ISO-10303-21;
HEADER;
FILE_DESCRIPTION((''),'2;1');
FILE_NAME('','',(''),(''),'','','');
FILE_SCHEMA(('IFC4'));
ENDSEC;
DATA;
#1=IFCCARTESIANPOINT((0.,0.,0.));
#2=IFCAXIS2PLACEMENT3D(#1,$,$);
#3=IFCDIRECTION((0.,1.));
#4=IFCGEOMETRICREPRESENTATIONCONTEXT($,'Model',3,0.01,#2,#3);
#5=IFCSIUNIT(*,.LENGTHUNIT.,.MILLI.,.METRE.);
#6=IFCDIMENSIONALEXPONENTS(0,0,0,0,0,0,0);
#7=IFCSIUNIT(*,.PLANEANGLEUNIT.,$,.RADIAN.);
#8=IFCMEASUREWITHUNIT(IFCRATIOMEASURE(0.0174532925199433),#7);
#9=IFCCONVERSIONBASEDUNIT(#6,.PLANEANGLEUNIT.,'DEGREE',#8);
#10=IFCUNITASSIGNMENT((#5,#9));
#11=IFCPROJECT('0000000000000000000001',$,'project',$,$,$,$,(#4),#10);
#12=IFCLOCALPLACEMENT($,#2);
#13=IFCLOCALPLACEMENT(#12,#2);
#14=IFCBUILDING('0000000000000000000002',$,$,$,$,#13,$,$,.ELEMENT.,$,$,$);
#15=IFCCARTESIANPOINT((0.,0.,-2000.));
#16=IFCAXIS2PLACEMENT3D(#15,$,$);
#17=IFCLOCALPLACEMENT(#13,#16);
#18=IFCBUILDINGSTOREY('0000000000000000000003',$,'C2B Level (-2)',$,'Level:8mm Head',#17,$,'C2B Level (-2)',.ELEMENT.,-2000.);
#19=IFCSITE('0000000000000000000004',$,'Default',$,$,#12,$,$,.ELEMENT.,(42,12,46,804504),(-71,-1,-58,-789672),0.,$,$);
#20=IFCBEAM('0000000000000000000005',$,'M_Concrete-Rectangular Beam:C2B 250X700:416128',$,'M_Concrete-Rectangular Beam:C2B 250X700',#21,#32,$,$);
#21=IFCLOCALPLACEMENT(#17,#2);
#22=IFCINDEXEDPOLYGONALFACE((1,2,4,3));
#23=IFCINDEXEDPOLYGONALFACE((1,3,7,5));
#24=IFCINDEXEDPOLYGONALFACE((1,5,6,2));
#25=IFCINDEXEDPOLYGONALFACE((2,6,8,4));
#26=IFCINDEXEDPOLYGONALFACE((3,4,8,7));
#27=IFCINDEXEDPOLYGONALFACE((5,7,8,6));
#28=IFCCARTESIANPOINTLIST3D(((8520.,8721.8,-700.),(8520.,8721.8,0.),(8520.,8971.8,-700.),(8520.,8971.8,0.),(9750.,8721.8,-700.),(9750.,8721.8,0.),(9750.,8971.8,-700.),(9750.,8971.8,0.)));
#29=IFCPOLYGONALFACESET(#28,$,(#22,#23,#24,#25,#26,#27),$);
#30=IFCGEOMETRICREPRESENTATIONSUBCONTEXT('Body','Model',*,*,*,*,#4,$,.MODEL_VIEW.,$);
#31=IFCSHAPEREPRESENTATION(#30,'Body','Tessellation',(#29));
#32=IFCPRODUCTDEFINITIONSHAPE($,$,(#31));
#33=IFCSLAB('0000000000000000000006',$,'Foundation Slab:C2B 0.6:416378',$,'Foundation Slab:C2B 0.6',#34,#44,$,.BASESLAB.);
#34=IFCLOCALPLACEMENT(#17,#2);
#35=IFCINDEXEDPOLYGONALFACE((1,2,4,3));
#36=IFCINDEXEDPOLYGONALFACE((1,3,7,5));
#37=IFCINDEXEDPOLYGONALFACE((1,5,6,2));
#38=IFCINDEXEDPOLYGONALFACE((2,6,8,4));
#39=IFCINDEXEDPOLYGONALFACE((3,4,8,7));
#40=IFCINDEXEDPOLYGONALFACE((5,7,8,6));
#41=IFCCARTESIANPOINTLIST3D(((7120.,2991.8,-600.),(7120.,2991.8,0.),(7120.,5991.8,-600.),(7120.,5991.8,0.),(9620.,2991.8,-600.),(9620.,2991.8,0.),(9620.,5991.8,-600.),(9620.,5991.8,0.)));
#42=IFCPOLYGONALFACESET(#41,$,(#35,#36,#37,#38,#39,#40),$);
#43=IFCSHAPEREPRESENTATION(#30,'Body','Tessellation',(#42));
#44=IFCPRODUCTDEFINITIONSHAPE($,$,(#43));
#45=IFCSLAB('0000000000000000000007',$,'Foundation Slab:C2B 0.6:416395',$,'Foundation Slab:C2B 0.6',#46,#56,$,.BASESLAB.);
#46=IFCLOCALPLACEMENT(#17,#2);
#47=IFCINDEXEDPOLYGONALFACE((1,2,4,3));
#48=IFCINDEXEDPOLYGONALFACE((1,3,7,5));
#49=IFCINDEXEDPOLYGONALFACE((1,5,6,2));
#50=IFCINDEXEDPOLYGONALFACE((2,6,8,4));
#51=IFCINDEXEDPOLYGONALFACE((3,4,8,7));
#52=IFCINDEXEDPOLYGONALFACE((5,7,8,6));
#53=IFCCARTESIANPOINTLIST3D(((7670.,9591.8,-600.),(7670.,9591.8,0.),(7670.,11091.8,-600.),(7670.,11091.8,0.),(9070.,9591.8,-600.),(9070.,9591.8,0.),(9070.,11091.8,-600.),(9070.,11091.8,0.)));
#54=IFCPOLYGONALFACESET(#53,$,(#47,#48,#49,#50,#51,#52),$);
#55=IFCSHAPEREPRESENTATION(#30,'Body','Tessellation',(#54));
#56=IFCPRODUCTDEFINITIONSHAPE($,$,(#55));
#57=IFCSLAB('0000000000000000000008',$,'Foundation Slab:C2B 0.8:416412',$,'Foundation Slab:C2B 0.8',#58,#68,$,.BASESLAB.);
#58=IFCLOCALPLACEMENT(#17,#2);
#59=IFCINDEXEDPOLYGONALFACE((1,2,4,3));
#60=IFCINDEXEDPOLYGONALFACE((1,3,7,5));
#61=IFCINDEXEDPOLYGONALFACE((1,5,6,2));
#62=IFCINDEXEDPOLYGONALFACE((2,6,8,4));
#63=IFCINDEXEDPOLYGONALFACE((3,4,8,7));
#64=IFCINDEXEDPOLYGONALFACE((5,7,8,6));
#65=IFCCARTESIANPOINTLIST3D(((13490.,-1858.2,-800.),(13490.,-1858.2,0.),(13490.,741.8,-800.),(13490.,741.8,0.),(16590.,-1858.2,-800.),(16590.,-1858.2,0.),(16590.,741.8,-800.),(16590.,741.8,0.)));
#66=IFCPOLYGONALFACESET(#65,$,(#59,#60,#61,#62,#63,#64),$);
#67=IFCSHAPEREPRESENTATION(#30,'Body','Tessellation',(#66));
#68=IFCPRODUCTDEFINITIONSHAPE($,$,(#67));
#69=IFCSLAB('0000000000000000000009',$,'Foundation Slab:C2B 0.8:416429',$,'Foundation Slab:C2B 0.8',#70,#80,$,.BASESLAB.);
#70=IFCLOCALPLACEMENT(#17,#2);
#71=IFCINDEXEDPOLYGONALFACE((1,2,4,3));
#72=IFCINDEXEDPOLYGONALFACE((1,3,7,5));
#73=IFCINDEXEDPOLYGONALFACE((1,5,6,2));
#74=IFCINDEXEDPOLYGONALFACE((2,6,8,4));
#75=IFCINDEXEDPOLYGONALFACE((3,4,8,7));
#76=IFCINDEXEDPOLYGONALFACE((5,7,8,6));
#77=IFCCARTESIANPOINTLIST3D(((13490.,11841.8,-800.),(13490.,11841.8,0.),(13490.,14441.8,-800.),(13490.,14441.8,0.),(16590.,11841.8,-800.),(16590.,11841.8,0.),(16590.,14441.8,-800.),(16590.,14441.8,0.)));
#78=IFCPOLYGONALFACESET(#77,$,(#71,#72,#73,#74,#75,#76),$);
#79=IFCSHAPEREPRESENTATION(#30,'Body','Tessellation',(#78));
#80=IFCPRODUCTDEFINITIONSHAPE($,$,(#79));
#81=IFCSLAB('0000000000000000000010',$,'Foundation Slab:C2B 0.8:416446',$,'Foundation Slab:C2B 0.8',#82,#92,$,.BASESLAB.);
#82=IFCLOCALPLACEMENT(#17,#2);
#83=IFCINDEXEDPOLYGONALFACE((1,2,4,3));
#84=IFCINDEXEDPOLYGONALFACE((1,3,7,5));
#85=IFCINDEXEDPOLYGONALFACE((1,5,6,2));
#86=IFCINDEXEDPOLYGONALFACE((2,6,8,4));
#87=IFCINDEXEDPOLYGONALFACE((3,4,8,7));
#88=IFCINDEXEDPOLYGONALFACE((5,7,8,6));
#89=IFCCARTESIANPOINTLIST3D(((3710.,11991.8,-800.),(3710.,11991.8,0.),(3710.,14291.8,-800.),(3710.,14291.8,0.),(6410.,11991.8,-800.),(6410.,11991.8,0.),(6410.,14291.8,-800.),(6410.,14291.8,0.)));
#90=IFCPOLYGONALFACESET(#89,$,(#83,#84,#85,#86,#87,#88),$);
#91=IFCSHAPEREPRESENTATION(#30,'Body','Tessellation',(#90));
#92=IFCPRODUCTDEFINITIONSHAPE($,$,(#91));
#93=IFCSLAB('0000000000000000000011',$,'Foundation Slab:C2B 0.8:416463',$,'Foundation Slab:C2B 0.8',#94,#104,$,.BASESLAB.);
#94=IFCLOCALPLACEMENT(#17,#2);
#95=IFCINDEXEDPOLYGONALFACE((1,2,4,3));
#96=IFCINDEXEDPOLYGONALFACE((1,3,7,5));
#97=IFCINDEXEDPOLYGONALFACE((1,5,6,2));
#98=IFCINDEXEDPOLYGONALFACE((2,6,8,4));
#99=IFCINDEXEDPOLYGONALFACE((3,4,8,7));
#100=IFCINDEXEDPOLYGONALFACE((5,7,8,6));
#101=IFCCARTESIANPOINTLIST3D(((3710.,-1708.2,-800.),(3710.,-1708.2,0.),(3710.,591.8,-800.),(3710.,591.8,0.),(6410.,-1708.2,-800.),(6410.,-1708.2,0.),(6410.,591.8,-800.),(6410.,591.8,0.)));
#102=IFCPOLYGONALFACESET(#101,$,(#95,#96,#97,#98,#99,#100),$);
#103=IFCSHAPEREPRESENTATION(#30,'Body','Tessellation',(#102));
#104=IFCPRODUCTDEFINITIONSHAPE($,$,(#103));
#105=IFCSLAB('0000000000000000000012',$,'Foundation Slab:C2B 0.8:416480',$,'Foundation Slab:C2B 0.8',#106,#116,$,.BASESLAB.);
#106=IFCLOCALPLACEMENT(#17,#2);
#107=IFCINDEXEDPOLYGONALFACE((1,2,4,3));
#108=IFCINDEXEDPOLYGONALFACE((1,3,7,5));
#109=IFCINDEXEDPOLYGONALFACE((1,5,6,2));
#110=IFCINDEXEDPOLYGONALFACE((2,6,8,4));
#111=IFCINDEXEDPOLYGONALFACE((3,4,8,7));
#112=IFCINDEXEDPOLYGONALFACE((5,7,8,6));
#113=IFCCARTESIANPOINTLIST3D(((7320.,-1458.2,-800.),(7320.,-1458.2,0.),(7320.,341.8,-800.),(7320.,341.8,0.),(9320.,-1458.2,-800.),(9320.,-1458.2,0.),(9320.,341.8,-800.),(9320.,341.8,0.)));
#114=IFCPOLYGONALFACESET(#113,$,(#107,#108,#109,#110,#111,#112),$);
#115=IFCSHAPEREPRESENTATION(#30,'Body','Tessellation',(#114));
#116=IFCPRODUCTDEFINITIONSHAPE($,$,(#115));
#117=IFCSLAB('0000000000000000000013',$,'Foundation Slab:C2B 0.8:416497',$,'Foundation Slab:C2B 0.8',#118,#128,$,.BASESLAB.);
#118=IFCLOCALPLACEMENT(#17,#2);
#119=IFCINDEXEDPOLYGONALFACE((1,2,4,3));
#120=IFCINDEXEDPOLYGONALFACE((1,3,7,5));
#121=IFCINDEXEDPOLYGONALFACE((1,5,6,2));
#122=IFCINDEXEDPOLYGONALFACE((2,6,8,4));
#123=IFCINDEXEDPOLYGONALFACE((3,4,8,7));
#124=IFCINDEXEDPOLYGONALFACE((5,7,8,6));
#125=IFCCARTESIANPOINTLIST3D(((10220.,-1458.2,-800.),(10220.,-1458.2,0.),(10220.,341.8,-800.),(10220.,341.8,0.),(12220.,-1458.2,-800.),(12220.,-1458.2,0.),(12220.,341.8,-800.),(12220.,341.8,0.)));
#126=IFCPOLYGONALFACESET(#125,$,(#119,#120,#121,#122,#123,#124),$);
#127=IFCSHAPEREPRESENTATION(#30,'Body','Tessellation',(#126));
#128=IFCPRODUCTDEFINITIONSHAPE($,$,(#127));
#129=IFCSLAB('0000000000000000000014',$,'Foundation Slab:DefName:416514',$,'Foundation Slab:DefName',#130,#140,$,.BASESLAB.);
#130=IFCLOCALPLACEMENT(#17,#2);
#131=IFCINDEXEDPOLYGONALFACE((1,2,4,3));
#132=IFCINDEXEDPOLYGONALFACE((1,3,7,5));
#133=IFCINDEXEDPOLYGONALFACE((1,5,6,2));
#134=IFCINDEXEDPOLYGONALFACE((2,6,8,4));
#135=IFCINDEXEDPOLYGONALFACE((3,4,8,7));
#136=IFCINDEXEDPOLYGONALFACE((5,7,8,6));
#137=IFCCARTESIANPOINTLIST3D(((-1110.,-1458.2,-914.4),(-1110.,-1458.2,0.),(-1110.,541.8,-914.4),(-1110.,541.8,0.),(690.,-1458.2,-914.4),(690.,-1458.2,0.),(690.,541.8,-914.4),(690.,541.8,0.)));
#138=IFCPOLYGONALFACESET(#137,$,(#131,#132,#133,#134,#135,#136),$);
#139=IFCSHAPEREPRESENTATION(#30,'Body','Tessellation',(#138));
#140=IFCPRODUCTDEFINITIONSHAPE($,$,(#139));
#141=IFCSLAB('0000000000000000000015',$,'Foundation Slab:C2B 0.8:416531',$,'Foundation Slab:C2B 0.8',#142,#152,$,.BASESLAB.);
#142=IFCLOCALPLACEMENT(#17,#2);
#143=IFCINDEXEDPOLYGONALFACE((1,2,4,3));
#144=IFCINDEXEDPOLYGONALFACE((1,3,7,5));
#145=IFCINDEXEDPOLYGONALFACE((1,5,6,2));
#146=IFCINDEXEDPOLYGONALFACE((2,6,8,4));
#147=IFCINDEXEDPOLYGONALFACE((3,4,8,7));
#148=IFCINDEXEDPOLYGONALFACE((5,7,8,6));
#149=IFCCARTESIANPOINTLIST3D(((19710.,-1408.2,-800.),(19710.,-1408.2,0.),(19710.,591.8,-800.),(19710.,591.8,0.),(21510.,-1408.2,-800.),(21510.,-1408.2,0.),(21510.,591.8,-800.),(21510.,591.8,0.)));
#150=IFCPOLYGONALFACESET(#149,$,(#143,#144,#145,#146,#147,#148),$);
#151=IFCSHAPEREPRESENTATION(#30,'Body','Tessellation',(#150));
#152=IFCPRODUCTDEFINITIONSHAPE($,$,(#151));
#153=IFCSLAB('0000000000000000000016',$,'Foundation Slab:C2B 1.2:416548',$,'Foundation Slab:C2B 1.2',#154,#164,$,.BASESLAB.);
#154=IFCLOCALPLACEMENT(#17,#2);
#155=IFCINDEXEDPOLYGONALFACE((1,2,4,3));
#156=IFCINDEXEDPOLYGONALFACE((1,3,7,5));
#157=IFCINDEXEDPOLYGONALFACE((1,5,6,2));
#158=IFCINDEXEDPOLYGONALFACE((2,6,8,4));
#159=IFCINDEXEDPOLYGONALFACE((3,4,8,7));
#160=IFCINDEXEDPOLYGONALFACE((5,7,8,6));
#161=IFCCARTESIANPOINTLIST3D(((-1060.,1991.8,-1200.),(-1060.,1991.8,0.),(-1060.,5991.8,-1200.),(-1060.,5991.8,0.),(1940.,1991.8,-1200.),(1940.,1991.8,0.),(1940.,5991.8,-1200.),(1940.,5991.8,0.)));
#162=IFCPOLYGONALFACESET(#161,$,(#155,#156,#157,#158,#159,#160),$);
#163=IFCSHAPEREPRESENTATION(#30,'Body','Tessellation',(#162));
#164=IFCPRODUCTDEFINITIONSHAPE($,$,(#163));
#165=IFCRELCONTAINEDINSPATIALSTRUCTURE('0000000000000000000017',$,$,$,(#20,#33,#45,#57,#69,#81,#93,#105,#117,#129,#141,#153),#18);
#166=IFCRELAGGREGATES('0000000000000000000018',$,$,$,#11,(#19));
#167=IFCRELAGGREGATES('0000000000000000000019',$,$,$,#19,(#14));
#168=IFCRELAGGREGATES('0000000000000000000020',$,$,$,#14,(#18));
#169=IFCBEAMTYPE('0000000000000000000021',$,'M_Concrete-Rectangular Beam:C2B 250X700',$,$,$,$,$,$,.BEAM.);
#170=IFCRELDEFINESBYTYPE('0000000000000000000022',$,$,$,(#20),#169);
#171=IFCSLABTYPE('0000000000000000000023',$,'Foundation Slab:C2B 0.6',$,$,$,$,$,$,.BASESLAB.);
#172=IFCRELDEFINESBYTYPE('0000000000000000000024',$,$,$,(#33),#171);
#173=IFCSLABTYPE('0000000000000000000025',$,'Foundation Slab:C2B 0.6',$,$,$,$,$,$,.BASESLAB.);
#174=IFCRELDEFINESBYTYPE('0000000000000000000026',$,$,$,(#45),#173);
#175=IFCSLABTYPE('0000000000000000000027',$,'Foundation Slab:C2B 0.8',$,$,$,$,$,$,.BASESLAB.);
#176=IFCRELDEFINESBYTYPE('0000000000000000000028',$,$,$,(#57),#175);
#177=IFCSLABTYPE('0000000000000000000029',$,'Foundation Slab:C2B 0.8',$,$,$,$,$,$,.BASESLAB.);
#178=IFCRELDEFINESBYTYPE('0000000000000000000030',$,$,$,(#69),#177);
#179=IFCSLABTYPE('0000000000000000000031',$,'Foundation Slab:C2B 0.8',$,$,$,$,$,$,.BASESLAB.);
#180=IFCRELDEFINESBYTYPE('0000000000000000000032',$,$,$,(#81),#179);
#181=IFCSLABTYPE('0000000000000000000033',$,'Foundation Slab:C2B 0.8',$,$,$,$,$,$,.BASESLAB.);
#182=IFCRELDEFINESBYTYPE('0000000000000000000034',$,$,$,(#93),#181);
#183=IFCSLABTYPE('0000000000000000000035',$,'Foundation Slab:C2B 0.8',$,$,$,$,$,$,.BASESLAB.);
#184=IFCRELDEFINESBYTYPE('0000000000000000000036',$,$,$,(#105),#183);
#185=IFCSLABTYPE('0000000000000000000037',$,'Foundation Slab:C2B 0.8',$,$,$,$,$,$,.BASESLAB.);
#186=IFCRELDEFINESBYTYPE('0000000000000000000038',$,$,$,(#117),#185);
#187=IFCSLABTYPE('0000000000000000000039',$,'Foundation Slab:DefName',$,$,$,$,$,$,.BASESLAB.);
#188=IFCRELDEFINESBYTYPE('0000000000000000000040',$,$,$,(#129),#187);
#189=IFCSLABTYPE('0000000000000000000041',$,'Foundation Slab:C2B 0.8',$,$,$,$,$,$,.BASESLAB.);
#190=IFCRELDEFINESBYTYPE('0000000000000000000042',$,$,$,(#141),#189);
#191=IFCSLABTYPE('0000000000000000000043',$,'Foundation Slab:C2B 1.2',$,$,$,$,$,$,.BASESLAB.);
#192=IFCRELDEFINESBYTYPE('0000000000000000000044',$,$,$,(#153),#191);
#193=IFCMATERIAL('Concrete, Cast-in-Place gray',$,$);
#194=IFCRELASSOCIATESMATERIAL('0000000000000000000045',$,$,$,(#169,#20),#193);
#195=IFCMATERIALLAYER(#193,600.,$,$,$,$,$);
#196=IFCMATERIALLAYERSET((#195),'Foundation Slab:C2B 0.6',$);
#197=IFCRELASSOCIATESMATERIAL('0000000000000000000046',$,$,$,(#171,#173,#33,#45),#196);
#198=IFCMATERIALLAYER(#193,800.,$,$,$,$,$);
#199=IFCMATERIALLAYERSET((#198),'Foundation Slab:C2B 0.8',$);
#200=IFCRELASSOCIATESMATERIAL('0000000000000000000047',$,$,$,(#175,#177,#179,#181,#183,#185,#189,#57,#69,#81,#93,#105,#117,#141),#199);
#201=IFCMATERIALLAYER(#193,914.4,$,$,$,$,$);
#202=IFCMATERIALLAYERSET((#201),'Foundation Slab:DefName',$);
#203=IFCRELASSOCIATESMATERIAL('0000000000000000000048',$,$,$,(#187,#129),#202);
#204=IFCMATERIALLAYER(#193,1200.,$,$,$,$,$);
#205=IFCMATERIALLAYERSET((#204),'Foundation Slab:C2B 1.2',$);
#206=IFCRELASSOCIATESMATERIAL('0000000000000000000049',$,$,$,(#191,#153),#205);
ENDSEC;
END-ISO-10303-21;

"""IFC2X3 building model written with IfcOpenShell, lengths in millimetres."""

from ifc_helpers import new_model, entity, si_unit, converted_unit, direction, frame, frame_2d, origin, origin_2d_with_axis, place, context, subcontext, project, spatial, rectangle, extrude, material, layer, layer_set, layer_usage, type_object, element, save


model = new_model("IFC2X3")

# Units and contexts
model_context = context("Model", 3, precision=0.01, world=origin(), true_north=direction((0.0, 1.0)))
body_context = subcontext(model_context, "Body", "Model", "MODEL_VIEW")
ifc_project = project(units=[si_unit("LENGTHUNIT", "METRE", prefix="MILLI"), converted_unit("PLANEANGLEUNIT", "DEGREE", entity("IfcRatioMeasure", 0.0174532925199433), si_unit("PLANEANGLEUNIT", "RADIAN"), dimensions=[0, 0, 0, 0, 0, 0, 0])], contexts=[model_context])

# Site, building, storey
site_placement = place(None, origin())
site = spatial("IfcSite", under=ifc_project, at=site_placement, Name="Default", CompositionType="ELEMENT", RefLatitude=(42, 12, 46, 804504), RefLongitude=(-71, -1, -58, -789672), RefElevation=0.0)
building_placement = place(site_placement, origin())
building = spatial("IfcBuilding", under=site, at=building_placement, CompositionType="ELEMENT")
storey_placement = place(building_placement, frame((0.0, 0.0, -2000.0)))
storey = spatial("IfcBuildingStorey", under=building, at=storey_placement, Name="C2B Level (-2)", ObjectType="Level:8mm Head", LongName="C2B Level (-2)", CompositionType="ELEMENT", Elevation=-2000.0)

# Beam
ifc_material = material(Name="Concrete, Cast-in-Place gray")
beam_type = type_object("IfcBeamType", Name="M_Concrete-Rectangular Beam:C2B 250X700", PredefinedType="BEAM", material=ifc_material)
beam_1_placement = place(storey_placement, frame((8395.0, 8846.8, 0.0)))
element("IfcBeam", 1, at=beam_1_placement, inside=storey, type_object=beam_type, material=ifc_material, Name="M_Concrete-Rectangular Beam:C2B 250X700:416128", ObjectType="M_Concrete-Rectangular Beam:C2B 250X700", context=body_context, shape_type="SweptSolid", body=[
    extrude(rectangle(XDim=700.0, YDim=250.0, at=frame_2d((0.0, 0.0), x_axis=(1.0, 0.0))), frame((125.0, 0.0, -350.0), z_axis=(1.0, 0.0, 0.0), x_axis=(0.0, 0.0, -1.0)), (0.0, 0.0, 1.0), 1230.0),
])

# Slabs
ifc_layer_1 = layer(ifc_material, 600.0)
ifc_layer_set_1 = layer_set([ifc_layer_1], Name="Foundation Slab:C2B 0.6")
ifc_layer_usage_1 = layer_usage(ifc_layer_set_1, "AXIS3", "POSITIVE", 0.0)
slab_type_1 = type_object("IfcSlabType", Name="Foundation Slab:C2B 0.6", PredefinedType="BASESLAB", material=ifc_layer_set_1)
slab_1_placement = place(storey_placement, origin())
element("IfcSlab", 2, at=slab_1_placement, inside=storey, type_object=slab_type_1, material=ifc_layer_usage_1, Name="Foundation Slab:C2B 0.6:416378", ObjectType="Foundation Slab:C2B 0.6", PredefinedType="BASESLAB", context=body_context, shape_type="SweptSolid", body=[
    extrude(rectangle(XDim=3000.0, YDim=2500.0, at=frame_2d((0.0, 0.0), x_axis=(1.0, 0.0))), frame((8370.0, 4491.8, 0.0), z_axis=(0.0, 0.0, -1.0), x_axis=(0.0, 1.0, 0.0)), (0.0, 0.0, 1.0), 600.0),
])
ifc_layer_usage_2 = layer_usage(ifc_layer_set_1, "AXIS3", "POSITIVE", 0.0)
slab_type_2 = type_object("IfcSlabType", Name="Foundation Slab:C2B 0.6", PredefinedType="BASESLAB", material=ifc_layer_set_1)
slab_2_placement = place(storey_placement, origin())
element("IfcSlab", 3, at=slab_2_placement, inside=storey, type_object=slab_type_2, material=ifc_layer_usage_2, Name="Foundation Slab:C2B 0.6:416395", ObjectType="Foundation Slab:C2B 0.6", PredefinedType="BASESLAB", context=body_context, shape_type="SweptSolid", body=[
    extrude(rectangle(XDim=1500.0, YDim=1400.0, at=frame_2d((0.0, 0.0), x_axis=(1.0, 0.0))), frame((8370.0, 10341.8, 0.0), z_axis=(0.0, 0.0, -1.0), x_axis=(0.0, 1.0, 0.0)), (0.0, 0.0, 1.0), 600.0),
])
ifc_layer_2 = layer(ifc_material, 800.0)
ifc_layer_set_2 = layer_set([ifc_layer_2], Name="Foundation Slab:C2B 0.8")
ifc_layer_usage_3 = layer_usage(ifc_layer_set_2, "AXIS3", "POSITIVE", 0.0)
slab_type_3 = type_object("IfcSlabType", Name="Foundation Slab:C2B 0.8", PredefinedType="BASESLAB", material=ifc_layer_set_2)
slab_3_placement = place(storey_placement, origin())
element("IfcSlab", 4, at=slab_3_placement, inside=storey, type_object=slab_type_3, material=ifc_layer_usage_3, Name="Foundation Slab:C2B 0.8:416412", ObjectType="Foundation Slab:C2B 0.8", PredefinedType="BASESLAB", context=body_context, shape_type="SweptSolid", body=[
    extrude(rectangle(XDim=2600.0, YDim=3100.0, at=origin_2d_with_axis()), frame((15040.0, -558.2, 0.0), z_axis=(0.0, 0.0, -1.0), x_axis=(0.0, 1.0, 0.0)), (0.0, 0.0, 1.0), 800.0),
])
ifc_layer_usage_4 = layer_usage(ifc_layer_set_2, "AXIS3", "POSITIVE", 0.0)
slab_type_4 = type_object("IfcSlabType", Name="Foundation Slab:C2B 0.8", PredefinedType="BASESLAB", material=ifc_layer_set_2)
slab_4_placement = place(storey_placement, origin())
element("IfcSlab", 5, at=slab_4_placement, inside=storey, type_object=slab_type_4, material=ifc_layer_usage_4, Name="Foundation Slab:C2B 0.8:416429", ObjectType="Foundation Slab:C2B 0.8", PredefinedType="BASESLAB", context=body_context, shape_type="SweptSolid", body=[
    extrude(rectangle(XDim=2600.0, YDim=3100.0, at=origin_2d_with_axis()), frame((15040.0, 13141.8, 0.0), z_axis=(0.0, 0.0, -1.0), x_axis=(0.0, 1.0, 0.0)), (0.0, 0.0, 1.0), 800.0),
])
ifc_layer_usage_5 = layer_usage(ifc_layer_set_2, "AXIS3", "POSITIVE", 0.0)
slab_type_5 = type_object("IfcSlabType", Name="Foundation Slab:C2B 0.8", PredefinedType="BASESLAB", material=ifc_layer_set_2)
slab_5_placement = place(storey_placement, origin())
element("IfcSlab", 6, at=slab_5_placement, inside=storey, type_object=slab_type_5, material=ifc_layer_usage_5, Name="Foundation Slab:C2B 0.8:416446", ObjectType="Foundation Slab:C2B 0.8", PredefinedType="BASESLAB", context=body_context, shape_type="SweptSolid", body=[
    extrude(rectangle(XDim=2300.0, YDim=2700.0, at=frame_2d((0.0, 0.0), x_axis=(1.0, 0.0))), frame((5060.0, 13141.8, 0.0), z_axis=(0.0, 0.0, -1.0), x_axis=(0.0, 1.0, 0.0)), (0.0, 0.0, 1.0), 800.0),
])
ifc_layer_usage_6 = layer_usage(ifc_layer_set_2, "AXIS3", "POSITIVE", 0.0)
slab_type_6 = type_object("IfcSlabType", Name="Foundation Slab:C2B 0.8", PredefinedType="BASESLAB", material=ifc_layer_set_2)
slab_6_placement = place(storey_placement, origin())
element("IfcSlab", 7, at=slab_6_placement, inside=storey, type_object=slab_type_6, material=ifc_layer_usage_6, Name="Foundation Slab:C2B 0.8:416463", ObjectType="Foundation Slab:C2B 0.8", PredefinedType="BASESLAB", context=body_context, shape_type="SweptSolid", body=[
    extrude(rectangle(XDim=2300.0, YDim=2700.0, at=frame_2d((0.0, 0.0), x_axis=(1.0, 0.0))), frame((5060.0, -558.2, 0.0), z_axis=(0.0, 0.0, -1.0), x_axis=(0.0, 1.0, 0.0)), (0.0, 0.0, 1.0), 800.0),
])
ifc_layer_usage_7 = layer_usage(ifc_layer_set_2, "AXIS3", "POSITIVE", 0.0)
slab_type_7 = type_object("IfcSlabType", Name="Foundation Slab:C2B 0.8", PredefinedType="BASESLAB", material=ifc_layer_set_2)
slab_7_placement = place(storey_placement, origin())
element("IfcSlab", 8, at=slab_7_placement, inside=storey, type_object=slab_type_7, material=ifc_layer_usage_7, Name="Foundation Slab:C2B 0.8:416480", ObjectType="Foundation Slab:C2B 0.8", PredefinedType="BASESLAB", context=body_context, shape_type="SweptSolid", body=[
    extrude(rectangle(XDim=1800.0, YDim=2000.0, at=origin_2d_with_axis()), frame((8320.0, -558.2, 0.0), z_axis=(0.0, 0.0, -1.0), x_axis=(0.0, 1.0, 0.0)), (0.0, 0.0, 1.0), 800.0),
])
ifc_layer_usage_8 = layer_usage(ifc_layer_set_2, "AXIS3", "POSITIVE", 0.0)
slab_type_8 = type_object("IfcSlabType", Name="Foundation Slab:C2B 0.8", PredefinedType="BASESLAB", material=ifc_layer_set_2)
slab_8_placement = place(storey_placement, origin())
element("IfcSlab", 9, at=slab_8_placement, inside=storey, type_object=slab_type_8, material=ifc_layer_usage_8, Name="Foundation Slab:C2B 0.8:416497", ObjectType="Foundation Slab:C2B 0.8", PredefinedType="BASESLAB", context=body_context, shape_type="SweptSolid", body=[
    extrude(rectangle(XDim=1800.0, YDim=2000.0, at=origin_2d_with_axis()), frame((11220.0, -558.2, 0.0), z_axis=(0.0, 0.0, -1.0), x_axis=(0.0, 1.0, 0.0)), (0.0, 0.0, 1.0), 800.0),
])
ifc_layer_3 = layer(ifc_material, 914.4)
ifc_layer_set_3 = layer_set([ifc_layer_3], Name="Foundation Slab:DefName")
ifc_layer_usage_9 = layer_usage(ifc_layer_set_3, "AXIS3", "POSITIVE", 0.0)
slab_type_9 = type_object("IfcSlabType", Name="Foundation Slab:DefName", PredefinedType="BASESLAB", material=ifc_layer_set_3)
slab_9_placement = place(storey_placement, origin())
element("IfcSlab", 10, at=slab_9_placement, inside=storey, type_object=slab_type_9, material=ifc_layer_usage_9, Name="Foundation Slab:DefName:416514", ObjectType="Foundation Slab:DefName", PredefinedType="BASESLAB", context=body_context, shape_type="SweptSolid", body=[
    extrude(rectangle(XDim=2000.0, YDim=1800.0, at=origin_2d_with_axis()), frame((-210.0, -458.2, 0.0), z_axis=(0.0, 0.0, -1.0), x_axis=(0.0, 1.0, 0.0)), (0.0, 0.0, 1.0), 914.4),
])
ifc_layer_usage_10 = layer_usage(ifc_layer_set_2, "AXIS3", "POSITIVE", 0.0)
slab_type_10 = type_object("IfcSlabType", Name="Foundation Slab:C2B 0.8", PredefinedType="BASESLAB", material=ifc_layer_set_2)
slab_10_placement = place(storey_placement, origin())
element("IfcSlab", 11, at=slab_10_placement, inside=storey, type_object=slab_type_10, material=ifc_layer_usage_10, Name="Foundation Slab:C2B 0.8:416531", ObjectType="Foundation Slab:C2B 0.8", PredefinedType="BASESLAB", context=body_context, shape_type="SweptSolid", body=[
    extrude(rectangle(XDim=2000.0, YDim=1800.0, at=origin_2d_with_axis()), frame((20610.0, -408.2, 0.0), z_axis=(0.0, 0.0, -1.0), x_axis=(0.0, 1.0, 0.0)), (0.0, 0.0, 1.0), 800.0),
])
ifc_layer_4 = layer(ifc_material, 1200.0)
ifc_layer_set_4 = layer_set([ifc_layer_4], Name="Foundation Slab:C2B 1.2")
ifc_layer_usage_11 = layer_usage(ifc_layer_set_4, "AXIS3", "POSITIVE", 0.0)
slab_type_11 = type_object("IfcSlabType", Name="Foundation Slab:C2B 1.2", PredefinedType="BASESLAB", material=ifc_layer_set_4)
slab_11_placement = place(storey_placement, origin())
element("IfcSlab", 12, at=slab_11_placement, inside=storey, type_object=slab_type_11, material=ifc_layer_usage_11, Name="Foundation Slab:C2B 1.2:416548", ObjectType="Foundation Slab:C2B 1.2", PredefinedType="BASESLAB", context=body_context, shape_type="SweptSolid", body=[
    extrude(rectangle(XDim=4000.0, YDim=3000.0, at=frame_2d((0.0, 0.0), x_axis=(1.0, 0.0))), frame((440.0, 3991.8, 0.0), z_axis=(0.0, 0.0, -1.0), x_axis=(0.0, 1.0, 0.0)), (0.0, 0.0, 1.0), 1200.0),
])

save(model, "model.ifc")
